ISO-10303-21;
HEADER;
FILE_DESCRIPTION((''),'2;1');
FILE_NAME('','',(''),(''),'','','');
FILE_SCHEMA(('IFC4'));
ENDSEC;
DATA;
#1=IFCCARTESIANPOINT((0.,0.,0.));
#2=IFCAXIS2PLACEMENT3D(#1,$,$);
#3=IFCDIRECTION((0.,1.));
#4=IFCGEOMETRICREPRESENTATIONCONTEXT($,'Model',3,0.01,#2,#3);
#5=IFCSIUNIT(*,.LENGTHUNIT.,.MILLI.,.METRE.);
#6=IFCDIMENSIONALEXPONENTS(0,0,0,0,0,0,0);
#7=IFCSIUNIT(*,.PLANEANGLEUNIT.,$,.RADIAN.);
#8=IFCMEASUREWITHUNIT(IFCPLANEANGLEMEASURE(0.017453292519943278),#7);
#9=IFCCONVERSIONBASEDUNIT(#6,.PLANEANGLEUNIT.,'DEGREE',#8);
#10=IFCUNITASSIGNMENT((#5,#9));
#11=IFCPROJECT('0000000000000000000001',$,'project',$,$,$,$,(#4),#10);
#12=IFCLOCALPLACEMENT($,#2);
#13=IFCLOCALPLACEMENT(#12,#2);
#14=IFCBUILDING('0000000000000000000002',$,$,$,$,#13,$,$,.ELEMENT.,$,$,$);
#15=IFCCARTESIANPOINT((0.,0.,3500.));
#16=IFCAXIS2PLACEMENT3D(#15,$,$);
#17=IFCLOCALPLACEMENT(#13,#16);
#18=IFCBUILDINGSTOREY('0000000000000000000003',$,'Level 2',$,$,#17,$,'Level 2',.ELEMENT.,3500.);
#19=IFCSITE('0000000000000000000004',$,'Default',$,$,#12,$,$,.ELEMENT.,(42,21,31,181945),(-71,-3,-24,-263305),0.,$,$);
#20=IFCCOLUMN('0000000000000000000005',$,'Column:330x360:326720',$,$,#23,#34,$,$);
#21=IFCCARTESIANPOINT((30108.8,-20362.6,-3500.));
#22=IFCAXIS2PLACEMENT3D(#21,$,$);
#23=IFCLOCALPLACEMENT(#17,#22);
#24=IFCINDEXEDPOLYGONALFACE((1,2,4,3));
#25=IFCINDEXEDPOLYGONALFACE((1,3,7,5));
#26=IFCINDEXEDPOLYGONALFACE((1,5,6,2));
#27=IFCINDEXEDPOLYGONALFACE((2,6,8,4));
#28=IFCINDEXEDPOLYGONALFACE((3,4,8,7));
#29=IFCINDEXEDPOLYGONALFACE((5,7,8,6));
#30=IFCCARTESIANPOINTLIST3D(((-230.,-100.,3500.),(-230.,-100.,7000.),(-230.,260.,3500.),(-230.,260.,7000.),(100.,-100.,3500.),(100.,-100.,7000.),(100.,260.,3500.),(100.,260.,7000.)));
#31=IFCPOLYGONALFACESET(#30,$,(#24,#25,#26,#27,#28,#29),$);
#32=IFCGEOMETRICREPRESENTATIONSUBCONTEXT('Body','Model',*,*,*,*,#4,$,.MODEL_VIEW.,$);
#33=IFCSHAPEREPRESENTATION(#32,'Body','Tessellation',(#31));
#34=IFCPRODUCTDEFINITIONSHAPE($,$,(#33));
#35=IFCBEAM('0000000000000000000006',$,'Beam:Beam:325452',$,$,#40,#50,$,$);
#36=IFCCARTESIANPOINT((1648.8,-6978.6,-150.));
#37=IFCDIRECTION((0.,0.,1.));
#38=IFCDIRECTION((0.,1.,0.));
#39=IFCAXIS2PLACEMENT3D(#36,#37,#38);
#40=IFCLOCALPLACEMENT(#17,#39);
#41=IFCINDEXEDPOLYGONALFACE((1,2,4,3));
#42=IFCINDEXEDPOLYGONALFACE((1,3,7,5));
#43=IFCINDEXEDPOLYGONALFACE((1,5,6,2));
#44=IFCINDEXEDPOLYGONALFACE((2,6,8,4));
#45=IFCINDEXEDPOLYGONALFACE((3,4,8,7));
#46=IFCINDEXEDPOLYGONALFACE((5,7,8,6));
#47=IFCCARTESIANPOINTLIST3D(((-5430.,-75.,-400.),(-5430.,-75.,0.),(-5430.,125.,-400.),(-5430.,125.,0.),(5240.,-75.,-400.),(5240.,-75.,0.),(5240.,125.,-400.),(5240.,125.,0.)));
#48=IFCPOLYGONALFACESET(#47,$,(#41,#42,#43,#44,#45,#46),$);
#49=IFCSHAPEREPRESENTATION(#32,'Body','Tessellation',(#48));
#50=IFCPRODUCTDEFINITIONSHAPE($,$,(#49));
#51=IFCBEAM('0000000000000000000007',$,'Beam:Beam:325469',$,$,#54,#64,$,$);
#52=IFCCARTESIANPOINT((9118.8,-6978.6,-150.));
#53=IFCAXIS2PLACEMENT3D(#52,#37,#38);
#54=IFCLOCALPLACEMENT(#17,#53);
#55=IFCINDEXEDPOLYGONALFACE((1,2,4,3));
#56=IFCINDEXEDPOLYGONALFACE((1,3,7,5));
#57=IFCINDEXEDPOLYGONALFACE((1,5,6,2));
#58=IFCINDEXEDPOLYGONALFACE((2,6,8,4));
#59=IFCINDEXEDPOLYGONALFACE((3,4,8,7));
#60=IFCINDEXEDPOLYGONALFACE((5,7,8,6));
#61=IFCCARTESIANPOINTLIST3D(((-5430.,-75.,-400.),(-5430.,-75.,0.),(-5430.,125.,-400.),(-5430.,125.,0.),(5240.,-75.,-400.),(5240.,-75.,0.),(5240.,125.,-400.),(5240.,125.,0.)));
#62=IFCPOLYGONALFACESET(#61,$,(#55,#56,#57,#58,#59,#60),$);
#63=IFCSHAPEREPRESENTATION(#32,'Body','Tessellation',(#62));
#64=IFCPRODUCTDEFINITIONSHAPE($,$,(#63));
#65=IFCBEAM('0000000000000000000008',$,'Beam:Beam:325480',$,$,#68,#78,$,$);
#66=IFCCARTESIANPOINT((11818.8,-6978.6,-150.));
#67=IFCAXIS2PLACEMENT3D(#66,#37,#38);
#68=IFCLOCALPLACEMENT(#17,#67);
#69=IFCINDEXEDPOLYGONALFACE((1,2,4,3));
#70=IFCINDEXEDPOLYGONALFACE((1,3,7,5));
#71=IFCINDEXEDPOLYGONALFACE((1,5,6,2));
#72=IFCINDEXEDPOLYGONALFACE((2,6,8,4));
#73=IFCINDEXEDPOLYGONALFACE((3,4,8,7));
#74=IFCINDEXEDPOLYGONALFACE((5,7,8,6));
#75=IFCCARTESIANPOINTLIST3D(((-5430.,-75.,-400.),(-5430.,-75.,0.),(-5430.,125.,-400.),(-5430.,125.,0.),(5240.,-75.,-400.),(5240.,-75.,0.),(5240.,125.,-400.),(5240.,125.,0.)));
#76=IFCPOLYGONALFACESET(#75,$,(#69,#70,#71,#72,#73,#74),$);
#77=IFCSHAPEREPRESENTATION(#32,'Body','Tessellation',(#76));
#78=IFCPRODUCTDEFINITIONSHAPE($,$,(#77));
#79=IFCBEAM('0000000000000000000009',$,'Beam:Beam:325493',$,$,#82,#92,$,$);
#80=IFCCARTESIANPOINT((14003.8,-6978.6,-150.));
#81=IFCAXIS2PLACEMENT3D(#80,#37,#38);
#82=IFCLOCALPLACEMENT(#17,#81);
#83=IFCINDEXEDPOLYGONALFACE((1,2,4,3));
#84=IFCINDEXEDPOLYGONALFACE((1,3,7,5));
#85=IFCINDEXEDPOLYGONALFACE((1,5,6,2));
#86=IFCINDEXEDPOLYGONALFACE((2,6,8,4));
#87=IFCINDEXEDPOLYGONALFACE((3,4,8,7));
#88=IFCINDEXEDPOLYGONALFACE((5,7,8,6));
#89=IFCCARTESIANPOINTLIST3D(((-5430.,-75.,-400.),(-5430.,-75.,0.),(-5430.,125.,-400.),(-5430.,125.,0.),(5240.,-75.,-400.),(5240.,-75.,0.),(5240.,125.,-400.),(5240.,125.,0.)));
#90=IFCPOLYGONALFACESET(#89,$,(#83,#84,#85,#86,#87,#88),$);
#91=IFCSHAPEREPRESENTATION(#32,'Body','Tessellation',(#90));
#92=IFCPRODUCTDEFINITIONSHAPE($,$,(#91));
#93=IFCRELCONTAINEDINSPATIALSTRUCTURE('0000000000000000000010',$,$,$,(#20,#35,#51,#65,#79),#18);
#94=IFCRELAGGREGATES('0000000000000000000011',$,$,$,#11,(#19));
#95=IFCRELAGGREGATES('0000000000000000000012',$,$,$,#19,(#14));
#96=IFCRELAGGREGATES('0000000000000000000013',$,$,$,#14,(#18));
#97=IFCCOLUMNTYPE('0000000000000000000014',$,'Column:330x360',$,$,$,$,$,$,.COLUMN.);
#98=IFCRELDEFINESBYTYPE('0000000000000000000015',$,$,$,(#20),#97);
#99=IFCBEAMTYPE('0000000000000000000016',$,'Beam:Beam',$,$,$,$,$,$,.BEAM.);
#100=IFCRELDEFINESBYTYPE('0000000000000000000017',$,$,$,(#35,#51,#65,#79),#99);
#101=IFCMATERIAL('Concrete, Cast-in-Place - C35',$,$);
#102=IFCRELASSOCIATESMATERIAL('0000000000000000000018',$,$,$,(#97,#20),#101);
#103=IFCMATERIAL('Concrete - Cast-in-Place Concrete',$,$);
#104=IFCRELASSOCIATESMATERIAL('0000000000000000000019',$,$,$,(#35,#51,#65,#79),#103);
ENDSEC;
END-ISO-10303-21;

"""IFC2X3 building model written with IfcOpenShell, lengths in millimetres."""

from ifc_helpers import new_model, entity, si_unit, converted_unit, direction, frame, frame_2d, origin, origin_2d_with_axis, place, context, subcontext, project, spatial, rectangle, extrude, source, transform, mapped, material, type_object, type_shapes, element, save


model = new_model("IFC2X3")

# Units and contexts
model_context = context("Model", 3, precision=0.01, world=origin(), true_north=direction((0.0, 1.0)))
body_context = subcontext(model_context, "Body", "Model", "MODEL_VIEW")
ifc_project = project(units=[si_unit("LENGTHUNIT", "METRE", prefix="MILLI"), converted_unit("PLANEANGLEUNIT", "DEGREE", entity("IfcPlaneAngleMeasure", 0.017453292519943278), si_unit("PLANEANGLEUNIT", "RADIAN"), dimensions=[0, 0, 0, 0, 0, 0, 0])], contexts=[model_context])

# Site, building, storey
site_placement = place(None, origin())
site = spatial("IfcSite", under=ifc_project, at=site_placement, Name="Default", CompositionType="ELEMENT", RefLatitude=(42, 21, 31, 181945), RefLongitude=(-71, -3, -24, -263305), RefElevation=0.0)
building_placement = place(site_placement, origin())
building = spatial("IfcBuilding", under=site, at=building_placement, CompositionType="ELEMENT")
storey_placement = place(building_placement, frame((0.0, 0.0, 3500.0)))
storey = spatial("IfcBuildingStorey", under=building, at=storey_placement, Name="Level 2", LongName="Level 2", CompositionType="ELEMENT", Elevation=3500.0)

# Column
ifc_material_1 = material(Name="Concrete, Cast-in-Place - C35")
column_type_1 = type_object("IfcColumnType", Name="Column:330x360", PredefinedType="COLUMN", material=ifc_material_1)
shared_shape_1 = source(origin(), body_context, "Body", "SweptSolid", [
    extrude(rectangle(XDim=330.0, YDim=360.0, at=origin_2d_with_axis()), frame((-65.0, 80.0, 3500.0), z_axis=(0.0, 0.0, 1.0), x_axis=(-1.0, 0.0, 0.0)), (0.0, 0.0, 1.0), 3500.0),
])
type_shapes(column_type_1, [shared_shape_1])
column_placement = place(storey_placement, frame((30108.8, -20362.6, -3500.0)))
element("IfcColumn", 1, at=column_placement, inside=storey, type_object=column_type_1, material=ifc_material_1, Name="Column:330x360:326720", context=body_context, shape_type="MappedRepresentation", body=[
    mapped(shared_shape_1, transform((0.0, 0.0, 0.0), scale=1.0)),
])

# Beams
beam_type = type_object("IfcBeamType", Name="Beam:Beam", PredefinedType="BEAM")
ifc_material_2 = material(Name="Concrete - Cast-in-Place Concrete")
beam_1_placement = place(storey_placement, frame((1648.8, -6978.6, -150.0), z_axis=(0.0, 0.0, 1.0), x_axis=(0.0, 1.0, 0.0)))
element("IfcBeam", 2, at=beam_1_placement, inside=storey, type_object=beam_type, material=ifc_material_2, Name="Beam:Beam:325452", context=body_context, shape_type="SweptSolid", body=[
    extrude(rectangle(XDim=400.0, YDim=200.0, at=frame_2d((0.0, 0.0), x_axis=(1.0, 0.0))), frame((-5430.0, 25.0, -200.0), z_axis=(1.0, 0.0, 0.0), x_axis=(0.0, 0.0, -1.0)), (0.0, 0.0, 1.0), 10670.0),
])
beam_2_placement = place(storey_placement, frame((9118.8, -6978.6, -150.0), z_axis=(0.0, 0.0, 1.0), x_axis=(0.0, 1.0, 0.0)))
element("IfcBeam", 3, at=beam_2_placement, inside=storey, type_object=beam_type, material=ifc_material_2, Name="Beam:Beam:325469", context=body_context, shape_type="SweptSolid", body=[
    extrude(rectangle(XDim=400.0, YDim=200.0, at=frame_2d((0.0, 0.0), x_axis=(1.0, 0.0))), frame((-5430.0, 25.0, -200.0), z_axis=(1.0, 0.0, 0.0), x_axis=(0.0, 0.0, -1.0)), (0.0, 0.0, 1.0), 10670.0),
])
beam_3_placement = place(storey_placement, frame((11818.8, -6978.6, -150.0), z_axis=(0.0, 0.0, 1.0), x_axis=(0.0, 1.0, 0.0)))
element("IfcBeam", 4, at=beam_3_placement, inside=storey, type_object=beam_type, material=ifc_material_2, Name="Beam:Beam:325480", context=body_context, shape_type="SweptSolid", body=[
    extrude(rectangle(XDim=400.0, YDim=200.0, at=frame_2d((0.0, 0.0), x_axis=(1.0, 0.0))), frame((-5430.0, 25.0, -200.0), z_axis=(1.0, 0.0, 0.0), x_axis=(0.0, 0.0, -1.0)), (0.0, 0.0, 1.0), 10670.0),
])
beam_4_placement = place(storey_placement, frame((14003.8, -6978.6, -150.0), z_axis=(0.0, 0.0, 1.0), x_axis=(0.0, 1.0, 0.0)))
element("IfcBeam", 5, at=beam_4_placement, inside=storey, type_object=beam_type, material=ifc_material_2, Name="Beam:Beam:325493", context=body_context, shape_type="SweptSolid", body=[
    extrude(rectangle(XDim=400.0, YDim=200.0, at=frame_2d((0.0, 0.0), x_axis=(1.0, 0.0))), frame((-5430.0, 25.0, -200.0), z_axis=(1.0, 0.0, 0.0), x_axis=(0.0, 0.0, -1.0)), (0.0, 0.0, 1.0), 10670.0),
])

save(model, "model.ifc")
